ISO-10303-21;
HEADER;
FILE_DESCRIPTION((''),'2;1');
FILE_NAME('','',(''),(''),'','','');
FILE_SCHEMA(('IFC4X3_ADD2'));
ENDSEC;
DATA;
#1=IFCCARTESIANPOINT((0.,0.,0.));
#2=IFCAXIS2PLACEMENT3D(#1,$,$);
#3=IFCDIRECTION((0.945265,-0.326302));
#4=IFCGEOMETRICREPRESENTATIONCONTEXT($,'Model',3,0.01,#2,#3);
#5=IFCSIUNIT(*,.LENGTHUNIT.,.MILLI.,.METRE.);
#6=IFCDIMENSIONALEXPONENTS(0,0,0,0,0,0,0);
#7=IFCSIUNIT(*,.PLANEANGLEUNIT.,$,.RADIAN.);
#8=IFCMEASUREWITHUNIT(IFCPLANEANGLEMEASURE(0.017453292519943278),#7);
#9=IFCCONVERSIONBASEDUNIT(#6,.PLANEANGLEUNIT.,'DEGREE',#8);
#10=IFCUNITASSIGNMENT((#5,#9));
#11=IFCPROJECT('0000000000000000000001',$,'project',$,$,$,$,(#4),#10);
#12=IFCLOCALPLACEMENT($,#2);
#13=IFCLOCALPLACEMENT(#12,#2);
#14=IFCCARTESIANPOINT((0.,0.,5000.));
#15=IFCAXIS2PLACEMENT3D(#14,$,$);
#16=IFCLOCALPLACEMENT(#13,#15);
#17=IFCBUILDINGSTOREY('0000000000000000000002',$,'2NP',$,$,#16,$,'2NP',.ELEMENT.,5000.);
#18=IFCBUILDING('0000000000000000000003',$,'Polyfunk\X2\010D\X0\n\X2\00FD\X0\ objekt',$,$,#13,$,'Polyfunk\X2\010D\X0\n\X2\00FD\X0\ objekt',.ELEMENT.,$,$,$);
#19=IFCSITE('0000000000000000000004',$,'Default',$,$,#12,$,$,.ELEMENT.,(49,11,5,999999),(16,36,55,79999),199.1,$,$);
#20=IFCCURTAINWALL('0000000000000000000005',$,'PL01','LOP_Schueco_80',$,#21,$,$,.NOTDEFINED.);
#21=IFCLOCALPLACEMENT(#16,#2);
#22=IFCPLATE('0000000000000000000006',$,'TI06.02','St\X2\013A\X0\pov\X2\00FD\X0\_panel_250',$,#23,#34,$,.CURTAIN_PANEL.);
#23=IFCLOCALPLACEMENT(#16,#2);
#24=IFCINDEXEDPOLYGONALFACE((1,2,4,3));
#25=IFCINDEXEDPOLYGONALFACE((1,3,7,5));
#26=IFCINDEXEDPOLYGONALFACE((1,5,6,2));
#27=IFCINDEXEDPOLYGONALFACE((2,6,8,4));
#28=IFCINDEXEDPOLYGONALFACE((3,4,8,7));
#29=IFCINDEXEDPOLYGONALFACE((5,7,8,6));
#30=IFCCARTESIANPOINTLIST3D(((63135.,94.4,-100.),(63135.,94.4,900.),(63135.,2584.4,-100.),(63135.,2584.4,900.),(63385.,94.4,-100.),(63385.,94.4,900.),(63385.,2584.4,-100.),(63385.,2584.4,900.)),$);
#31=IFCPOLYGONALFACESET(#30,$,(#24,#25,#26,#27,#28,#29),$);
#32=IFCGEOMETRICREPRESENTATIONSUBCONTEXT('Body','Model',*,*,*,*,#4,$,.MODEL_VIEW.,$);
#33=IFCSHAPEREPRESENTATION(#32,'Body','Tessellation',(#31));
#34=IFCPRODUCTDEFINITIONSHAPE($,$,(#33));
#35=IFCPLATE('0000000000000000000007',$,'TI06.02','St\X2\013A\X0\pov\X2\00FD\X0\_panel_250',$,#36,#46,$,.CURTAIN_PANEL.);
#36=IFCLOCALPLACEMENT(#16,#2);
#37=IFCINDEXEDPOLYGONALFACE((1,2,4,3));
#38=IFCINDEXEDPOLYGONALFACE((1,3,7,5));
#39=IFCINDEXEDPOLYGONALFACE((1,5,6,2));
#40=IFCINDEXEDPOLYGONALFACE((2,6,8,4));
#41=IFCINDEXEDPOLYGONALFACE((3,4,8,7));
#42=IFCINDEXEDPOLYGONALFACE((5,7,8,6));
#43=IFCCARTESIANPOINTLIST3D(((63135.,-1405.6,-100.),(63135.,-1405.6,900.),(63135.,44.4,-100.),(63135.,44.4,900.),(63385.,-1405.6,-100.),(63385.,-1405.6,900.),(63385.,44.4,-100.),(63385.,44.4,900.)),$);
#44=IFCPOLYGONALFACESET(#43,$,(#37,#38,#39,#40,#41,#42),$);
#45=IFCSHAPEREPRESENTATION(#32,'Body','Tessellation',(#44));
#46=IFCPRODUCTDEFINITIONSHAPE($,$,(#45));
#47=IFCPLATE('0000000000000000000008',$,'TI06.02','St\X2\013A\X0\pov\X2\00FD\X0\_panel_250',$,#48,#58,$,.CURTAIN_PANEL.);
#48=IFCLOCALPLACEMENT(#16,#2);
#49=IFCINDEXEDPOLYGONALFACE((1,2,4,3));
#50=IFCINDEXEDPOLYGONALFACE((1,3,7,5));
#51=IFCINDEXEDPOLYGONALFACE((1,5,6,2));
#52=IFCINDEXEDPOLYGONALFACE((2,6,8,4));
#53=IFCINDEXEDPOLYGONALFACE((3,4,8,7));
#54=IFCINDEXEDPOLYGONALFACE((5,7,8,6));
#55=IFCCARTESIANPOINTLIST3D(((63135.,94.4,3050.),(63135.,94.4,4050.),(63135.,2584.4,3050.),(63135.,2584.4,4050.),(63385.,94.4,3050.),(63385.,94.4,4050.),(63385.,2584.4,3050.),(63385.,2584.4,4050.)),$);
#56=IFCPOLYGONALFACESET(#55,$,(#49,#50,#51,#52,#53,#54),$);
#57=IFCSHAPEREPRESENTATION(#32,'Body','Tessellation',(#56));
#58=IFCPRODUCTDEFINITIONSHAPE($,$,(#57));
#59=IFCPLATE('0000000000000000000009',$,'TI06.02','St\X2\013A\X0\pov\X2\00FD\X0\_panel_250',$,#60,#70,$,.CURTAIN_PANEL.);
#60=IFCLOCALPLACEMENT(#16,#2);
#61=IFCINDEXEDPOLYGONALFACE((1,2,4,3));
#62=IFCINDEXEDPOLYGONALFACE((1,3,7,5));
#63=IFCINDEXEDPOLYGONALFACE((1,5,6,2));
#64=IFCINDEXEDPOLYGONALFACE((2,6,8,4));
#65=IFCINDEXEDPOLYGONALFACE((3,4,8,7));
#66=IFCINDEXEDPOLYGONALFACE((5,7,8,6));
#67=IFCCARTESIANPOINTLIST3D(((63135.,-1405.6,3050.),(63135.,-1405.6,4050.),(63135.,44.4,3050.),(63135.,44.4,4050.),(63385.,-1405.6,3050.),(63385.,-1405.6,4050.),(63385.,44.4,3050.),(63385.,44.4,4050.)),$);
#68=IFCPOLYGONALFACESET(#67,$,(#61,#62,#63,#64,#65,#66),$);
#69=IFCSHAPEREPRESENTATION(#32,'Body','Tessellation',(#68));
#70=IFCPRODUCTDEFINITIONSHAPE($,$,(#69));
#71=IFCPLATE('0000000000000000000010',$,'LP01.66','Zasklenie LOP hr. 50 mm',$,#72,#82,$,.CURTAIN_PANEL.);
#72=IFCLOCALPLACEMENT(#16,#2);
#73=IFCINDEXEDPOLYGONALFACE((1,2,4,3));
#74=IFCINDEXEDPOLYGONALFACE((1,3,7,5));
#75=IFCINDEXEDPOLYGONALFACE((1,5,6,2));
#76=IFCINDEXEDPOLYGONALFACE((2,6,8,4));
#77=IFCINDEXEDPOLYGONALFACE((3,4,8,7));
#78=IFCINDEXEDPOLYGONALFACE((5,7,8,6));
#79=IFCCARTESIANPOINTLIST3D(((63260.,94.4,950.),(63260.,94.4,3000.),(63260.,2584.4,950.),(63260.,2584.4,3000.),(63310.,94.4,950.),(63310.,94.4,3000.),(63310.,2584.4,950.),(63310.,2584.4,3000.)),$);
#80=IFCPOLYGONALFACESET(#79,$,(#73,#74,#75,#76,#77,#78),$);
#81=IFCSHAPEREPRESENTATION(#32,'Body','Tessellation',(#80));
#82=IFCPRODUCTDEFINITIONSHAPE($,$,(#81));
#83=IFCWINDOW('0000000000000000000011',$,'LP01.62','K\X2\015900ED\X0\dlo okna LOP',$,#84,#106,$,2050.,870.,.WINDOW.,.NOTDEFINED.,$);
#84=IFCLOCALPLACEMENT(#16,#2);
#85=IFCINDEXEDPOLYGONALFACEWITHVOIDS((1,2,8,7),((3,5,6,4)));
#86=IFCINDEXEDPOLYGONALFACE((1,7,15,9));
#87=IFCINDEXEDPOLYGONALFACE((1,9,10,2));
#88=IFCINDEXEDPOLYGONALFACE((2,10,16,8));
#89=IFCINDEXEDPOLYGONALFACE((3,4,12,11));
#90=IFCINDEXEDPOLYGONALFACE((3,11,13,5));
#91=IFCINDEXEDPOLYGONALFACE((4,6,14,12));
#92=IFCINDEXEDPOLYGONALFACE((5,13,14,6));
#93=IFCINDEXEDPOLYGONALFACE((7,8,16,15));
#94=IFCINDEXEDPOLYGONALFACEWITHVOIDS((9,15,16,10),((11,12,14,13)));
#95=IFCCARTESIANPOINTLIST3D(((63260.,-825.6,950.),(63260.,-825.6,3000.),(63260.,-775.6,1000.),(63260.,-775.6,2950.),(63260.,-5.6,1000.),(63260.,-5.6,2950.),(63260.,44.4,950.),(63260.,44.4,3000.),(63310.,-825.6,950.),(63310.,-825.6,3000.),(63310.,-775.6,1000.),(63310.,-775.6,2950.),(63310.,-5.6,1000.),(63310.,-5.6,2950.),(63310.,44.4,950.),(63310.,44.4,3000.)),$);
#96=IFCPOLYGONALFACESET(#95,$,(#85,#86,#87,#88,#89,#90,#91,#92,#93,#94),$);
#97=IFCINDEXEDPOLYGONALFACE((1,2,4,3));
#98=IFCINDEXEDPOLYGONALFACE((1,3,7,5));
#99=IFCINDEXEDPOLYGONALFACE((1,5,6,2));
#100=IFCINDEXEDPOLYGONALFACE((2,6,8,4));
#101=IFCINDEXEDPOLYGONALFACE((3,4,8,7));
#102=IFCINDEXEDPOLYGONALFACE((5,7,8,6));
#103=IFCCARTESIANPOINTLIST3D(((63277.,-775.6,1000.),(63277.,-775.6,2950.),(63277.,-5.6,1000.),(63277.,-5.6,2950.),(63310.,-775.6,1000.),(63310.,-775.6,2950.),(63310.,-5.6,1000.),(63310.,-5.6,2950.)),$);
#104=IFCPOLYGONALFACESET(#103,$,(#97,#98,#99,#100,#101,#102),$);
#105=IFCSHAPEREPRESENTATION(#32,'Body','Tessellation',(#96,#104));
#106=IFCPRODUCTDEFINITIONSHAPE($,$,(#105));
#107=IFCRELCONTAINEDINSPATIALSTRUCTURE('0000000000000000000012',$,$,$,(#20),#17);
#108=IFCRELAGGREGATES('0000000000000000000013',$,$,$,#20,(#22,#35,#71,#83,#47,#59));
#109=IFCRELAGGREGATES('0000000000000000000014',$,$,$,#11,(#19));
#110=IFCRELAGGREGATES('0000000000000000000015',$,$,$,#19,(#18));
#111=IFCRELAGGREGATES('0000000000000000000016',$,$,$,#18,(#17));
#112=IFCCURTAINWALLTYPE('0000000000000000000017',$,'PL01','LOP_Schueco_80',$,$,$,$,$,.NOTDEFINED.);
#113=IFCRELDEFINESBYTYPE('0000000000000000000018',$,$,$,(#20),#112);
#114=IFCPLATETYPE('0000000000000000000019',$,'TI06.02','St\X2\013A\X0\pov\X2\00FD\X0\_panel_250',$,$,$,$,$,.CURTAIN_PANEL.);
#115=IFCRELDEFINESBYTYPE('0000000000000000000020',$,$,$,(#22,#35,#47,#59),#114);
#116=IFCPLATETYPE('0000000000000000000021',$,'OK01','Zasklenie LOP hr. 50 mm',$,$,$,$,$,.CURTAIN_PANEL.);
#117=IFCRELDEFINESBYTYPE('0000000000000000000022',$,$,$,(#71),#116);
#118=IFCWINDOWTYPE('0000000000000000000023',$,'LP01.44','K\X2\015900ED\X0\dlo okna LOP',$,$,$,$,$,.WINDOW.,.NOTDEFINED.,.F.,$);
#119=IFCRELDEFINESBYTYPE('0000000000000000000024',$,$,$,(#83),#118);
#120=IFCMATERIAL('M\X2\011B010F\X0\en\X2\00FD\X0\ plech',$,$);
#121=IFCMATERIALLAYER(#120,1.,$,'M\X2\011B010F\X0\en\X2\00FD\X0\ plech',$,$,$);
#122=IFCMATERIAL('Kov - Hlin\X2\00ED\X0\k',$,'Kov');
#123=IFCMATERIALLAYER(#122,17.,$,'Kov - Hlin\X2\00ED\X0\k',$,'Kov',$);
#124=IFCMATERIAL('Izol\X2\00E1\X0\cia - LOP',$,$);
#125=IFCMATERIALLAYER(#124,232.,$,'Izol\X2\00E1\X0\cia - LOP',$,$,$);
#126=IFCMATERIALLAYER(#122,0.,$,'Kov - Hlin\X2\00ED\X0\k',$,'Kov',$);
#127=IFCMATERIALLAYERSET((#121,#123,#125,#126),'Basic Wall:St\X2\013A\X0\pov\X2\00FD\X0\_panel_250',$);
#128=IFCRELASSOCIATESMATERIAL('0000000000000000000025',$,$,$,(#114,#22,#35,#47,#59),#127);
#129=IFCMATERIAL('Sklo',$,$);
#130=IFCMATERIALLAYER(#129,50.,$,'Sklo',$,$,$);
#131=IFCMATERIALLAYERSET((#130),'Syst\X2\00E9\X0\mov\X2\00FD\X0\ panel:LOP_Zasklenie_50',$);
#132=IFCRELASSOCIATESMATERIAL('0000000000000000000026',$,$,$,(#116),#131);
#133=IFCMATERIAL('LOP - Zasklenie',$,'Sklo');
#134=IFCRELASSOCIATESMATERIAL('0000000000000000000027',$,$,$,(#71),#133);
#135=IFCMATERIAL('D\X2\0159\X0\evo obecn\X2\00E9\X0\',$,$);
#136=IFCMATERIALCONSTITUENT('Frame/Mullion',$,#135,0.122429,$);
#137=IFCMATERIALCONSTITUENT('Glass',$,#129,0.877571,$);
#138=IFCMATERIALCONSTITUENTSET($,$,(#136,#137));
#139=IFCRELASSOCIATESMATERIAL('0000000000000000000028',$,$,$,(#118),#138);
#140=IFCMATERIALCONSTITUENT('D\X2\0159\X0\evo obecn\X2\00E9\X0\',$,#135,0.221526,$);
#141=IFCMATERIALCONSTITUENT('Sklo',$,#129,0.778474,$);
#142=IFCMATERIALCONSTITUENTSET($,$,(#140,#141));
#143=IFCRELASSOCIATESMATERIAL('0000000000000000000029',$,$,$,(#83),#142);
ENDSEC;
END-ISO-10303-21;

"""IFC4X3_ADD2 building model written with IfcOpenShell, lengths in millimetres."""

from ifc_helpers import new_model, entity, si_unit, converted_unit, direction, frame, frame_2d, origin, origin_2d_with_axis, place, context, subcontext, project, spatial, polyline, rectangle, outline, extrude, source, transform, mapped, material, layer, layer_set, layer_usage, constituent, constituent_set, type_object, type_shapes, element, aggregate, save


model = new_model("IFC4X3_ADD2")

# Units and contexts
model_context = context("Model", 3, precision=0.01, world=origin(), true_north=direction((0.945265, -0.326302)))
body_context = subcontext(model_context, "Body", "Model", "MODEL_VIEW")
ifc_project = project(units=[si_unit("LENGTHUNIT", "METRE", prefix="MILLI"), converted_unit("PLANEANGLEUNIT", "DEGREE", entity("IfcPlaneAngleMeasure", 0.017453292519943278), si_unit("PLANEANGLEUNIT", "RADIAN"), dimensions=[0, 0, 0, 0, 0, 0, 0])], contexts=[model_context])

# Site, building, storey
site_placement = place(None, origin())
site = spatial("IfcSite", under=ifc_project, at=site_placement, Name="Default", CompositionType="ELEMENT", RefLatitude=(49, 11, 5, 999999), RefLongitude=(16, 36, 55, 79999), RefElevation=199.1)
building_placement = place(site_placement, origin())
building = spatial("IfcBuilding", under=site, at=building_placement, Name="Polyfunkčný objekt", LongName="Polyfunkčný objekt", CompositionType="ELEMENT")
storey_placement = place(building_placement, frame((0.0, 0.0, 5000.0)))
storey = spatial("IfcBuildingStorey", under=building, at=storey_placement, Name="2NP", LongName="2NP", CompositionType="ELEMENT", Elevation=5000.0)

# Curtain wall, plates, window
curtain_wall_type = type_object("IfcCurtainWallType", Name="PL01", Description="LOP_Schueco_80", PredefinedType="NOTDEFINED")
curtain_wall_placement = place(storey_placement, frame((0.0, 0.0, -5000.0)))
curtain_wall = element("IfcCurtainWall", 1, at=curtain_wall_placement, inside=storey, type_object=curtain_wall_type, Name="PL01", Description="LOP_Schueco_80", PredefinedType="NOTDEFINED")
ifc_material_1 = material(Name="Měďený plech")
ifc_layer_1 = layer(ifc_material_1, 1.0, Name="Měďený plech")
ifc_material_2 = material(Name="Kov - Hliník", Category="Kov")
ifc_layer_2 = layer(ifc_material_2, 17.0, Name="Kov - Hliník", Category="Kov")
ifc_material_3 = material(Name="Izolácia - LOP")
ifc_layer_3 = layer(ifc_material_3, 232.0, Name="Izolácia - LOP")
ifc_layer_4 = layer(ifc_material_2, 0.0, Name="Kov - Hliník", Category="Kov")
ifc_layer_set_1 = layer_set([ifc_layer_1, ifc_layer_2, ifc_layer_3, ifc_layer_4], Name="Basic Wall:Stĺpový_panel_250")
ifc_layer_usage_1 = layer_usage(ifc_layer_set_1, "AXIS2", "NEGATIVE", 125.0)
plate_type_1 = type_object("IfcPlateType", Name="TI06.02", Description="Stĺpový_panel_250", PredefinedType="CURTAIN_PANEL", material=ifc_layer_set_1)
plate_1_placement = place(storey_placement, frame((63260.0, 2584.4, -100.0), z_axis=(0.0, 0.0, 1.0), x_axis=(0.0, -1.0, 0.0)))
plate_1 = element("IfcPlate", 2, at=plate_1_placement, type_object=plate_type_1, material=ifc_layer_usage_1, Name="TI06.02", Description="Stĺpový_panel_250", PredefinedType="CURTAIN_PANEL", context=body_context, shape_type="SweptSolid", body=[
    extrude(rectangle(XDim=250.0, YDim=2490.0, at=frame_2d((0.0, 0.0), x_axis=(1.0, 0.0))), frame((1245.0, 0.0, 0.0), z_axis=(0.0, 0.0, 1.0), x_axis=(0.0, 1.0, 0.0)), (0.0, 0.0, 1.0), 1000.0),
])
ifc_layer_usage_2 = layer_usage(ifc_layer_set_1, "AXIS2", "NEGATIVE", 125.0)
plate_2_placement = place(storey_placement, frame((63260.0, 44.4, -100.0), z_axis=(0.0, 0.0, 1.0), x_axis=(0.0, -1.0, 0.0)))
plate_2 = element("IfcPlate", 3, at=plate_2_placement, type_object=plate_type_1, material=ifc_layer_usage_2, Name="TI06.02", Description="Stĺpový_panel_250", PredefinedType="CURTAIN_PANEL", context=body_context, shape_type="SweptSolid", body=[
    extrude(rectangle(XDim=250.0, YDim=1450.0, at=frame_2d((0.0, 0.0), x_axis=(1.0, 0.0))), frame((725.0, 0.0, 0.0), z_axis=(0.0, 0.0, 1.0), x_axis=(0.0, 1.0, 0.0)), (0.0, 0.0, 1.0), 1000.0),
])
ifc_layer_usage_3 = layer_usage(ifc_layer_set_1, "AXIS2", "NEGATIVE", 125.0)
plate_3_placement = place(storey_placement, frame((63260.0, 2584.4, 3050.0), z_axis=(0.0, 0.0, 1.0), x_axis=(0.0, -1.0, 0.0)))
plate_3 = element("IfcPlate", 4, at=plate_3_placement, type_object=plate_type_1, material=ifc_layer_usage_3, Name="TI06.02", Description="Stĺpový_panel_250", PredefinedType="CURTAIN_PANEL", context=body_context, shape_type="SweptSolid", body=[
    extrude(rectangle(XDim=250.0, YDim=2490.0, at=frame_2d((0.0, 0.0), x_axis=(1.0, 0.0))), frame((1245.0, 0.0, 0.0), z_axis=(0.0, 0.0, 1.0), x_axis=(0.0, 1.0, 0.0)), (0.0, 0.0, 1.0), 1000.0),
])
ifc_layer_usage_4 = layer_usage(ifc_layer_set_1, "AXIS2", "NEGATIVE", 125.0)
plate_4_placement = place(storey_placement, frame((63260.0, 44.4, 3050.0), z_axis=(0.0, 0.0, 1.0), x_axis=(0.0, -1.0, 0.0)))
plate_4 = element("IfcPlate", 5, at=plate_4_placement, type_object=plate_type_1, material=ifc_layer_usage_4, Name="TI06.02", Description="Stĺpový_panel_250", PredefinedType="CURTAIN_PANEL", context=body_context, shape_type="SweptSolid", body=[
    extrude(rectangle(XDim=250.0, YDim=1450.0, at=frame_2d((0.0, 0.0), x_axis=(1.0, 0.0))), frame((725.0, 0.0, 0.0), z_axis=(0.0, 0.0, 1.0), x_axis=(0.0, 1.0, 0.0)), (0.0, 0.0, 1.0), 1000.0),
])
ifc_material_4 = material(Name="LOP - Zasklenie", Category="Sklo")
ifc_material_5 = material(Name="Sklo")
ifc_layer_5 = layer(ifc_material_5, 50.0, Name="Sklo")
ifc_layer_set_2 = layer_set([ifc_layer_5], Name="Systémový panel:LOP_Zasklenie_50")
plate_type_2 = type_object("IfcPlateType", Name="OK01", Description="Zasklenie LOP hr. 50 mm", PredefinedType="CURTAIN_PANEL", material=ifc_layer_set_2)
shared_shape_1 = source(origin(), body_context, "Body", "SweptSolid", [
    extrude(rectangle(XDim=50.0, YDim=2490.0, at=origin_2d_with_axis()), frame((0.0, 25.0, 0.0), z_axis=(0.0, 0.0, 1.0), x_axis=(0.0, 1.0, 0.0)), (0.0, 0.0, 1.0), 2050.0),
])
type_shapes(plate_type_2, [shared_shape_1])
plate_5_placement = place(curtain_wall_placement, frame((63260.0, 1339.4, 5950.0), z_axis=(0.0, 0.0, 1.0), x_axis=(0.0, -1.0, 0.0)))
plate_5 = element("IfcPlate", 6, at=plate_5_placement, type_object=plate_type_2, material=ifc_material_4, Name="LP01.66", Description="Zasklenie LOP hr. 50 mm", PredefinedType="CURTAIN_PANEL", context=body_context, shape_type="MappedRepresentation", body=[
    mapped(shared_shape_1, transform((0.0, 0.0, 0.0), scale=1.0)),
])
ifc_material_6 = material(Name="Dřevo obecné")
ifc_constituent_1 = constituent(ifc_material_6, Name="Dřevo obecné", fraction=0.221526)
ifc_constituent_2 = constituent(ifc_material_5, Name="Sklo", fraction=0.778474)
ifc_constituent_set_1 = constituent_set(constituents=[ifc_constituent_1, ifc_constituent_2])
ifc_constituent_3 = constituent(ifc_material_6, Name="Frame/Mullion", fraction=0.122429)
ifc_constituent_4 = constituent(ifc_material_5, Name="Glass", fraction=0.877571)
ifc_constituent_set_2 = constituent_set(constituents=[ifc_constituent_3, ifc_constituent_4])
window_type = type_object("IfcWindowType", Name="LP01.44", Description="Křídlo okna LOP", ParameterTakesPrecedence=False, PartitioningType="NOTDEFINED", PredefinedType="WINDOW", material=ifc_constituent_set_2)
shared_shape_2 = source(origin(), body_context, "Body", "SweptSolid", [
    extrude(outline(polyline([(-1025.0, -435.0), (1025.0, -435.0), (1025.0, 435.0), (-1025.0, 435.0), (-1025.0, -435.0)]), holes=[polyline([(-975.0, -385.0), (-975.0, 385.0), (975.0, 385.0), (975.0, -385.0), (-975.0, -385.0)])]), frame((0.0, 0.0, 1025.0), z_axis=(0.0, 1.0, 0.0), x_axis=(0.0, 0.0, -1.0)), (0.0, 0.0, 1.0), 50.0),
    extrude(rectangle(XDim=33.0, YDim=770.0, at=origin_2d_with_axis()), frame((0.0, 33.5, 50.0), z_axis=(0.0, 0.0, 1.0), x_axis=(0.0, -1.0, 0.0)), (0.0, 0.0, 1.0), 1950.0),
])
type_shapes(window_type, [shared_shape_2])
window_placement = place(curtain_wall_placement, frame((63260.0, -390.6, 5950.0), z_axis=(0.0, 0.0, 1.0), x_axis=(0.0, -1.0, 0.0)))
window = element("IfcWindow", 7, at=window_placement, type_object=window_type, material=ifc_constituent_set_1, Name="LP01.62", Description="Křídlo okna LOP", OverallHeight=2050.0, OverallWidth=870.0, PartitioningType="NOTDEFINED", PredefinedType="WINDOW", context=body_context, shape_type="MappedRepresentation", body=[
    mapped(shared_shape_2, transform((0.0, 0.0, 0.0), scale=1.0)),
])
aggregate(curtain_wall, [plate_1, plate_2, plate_5, window, plate_3, plate_4])

save(model, "model.ifc")
